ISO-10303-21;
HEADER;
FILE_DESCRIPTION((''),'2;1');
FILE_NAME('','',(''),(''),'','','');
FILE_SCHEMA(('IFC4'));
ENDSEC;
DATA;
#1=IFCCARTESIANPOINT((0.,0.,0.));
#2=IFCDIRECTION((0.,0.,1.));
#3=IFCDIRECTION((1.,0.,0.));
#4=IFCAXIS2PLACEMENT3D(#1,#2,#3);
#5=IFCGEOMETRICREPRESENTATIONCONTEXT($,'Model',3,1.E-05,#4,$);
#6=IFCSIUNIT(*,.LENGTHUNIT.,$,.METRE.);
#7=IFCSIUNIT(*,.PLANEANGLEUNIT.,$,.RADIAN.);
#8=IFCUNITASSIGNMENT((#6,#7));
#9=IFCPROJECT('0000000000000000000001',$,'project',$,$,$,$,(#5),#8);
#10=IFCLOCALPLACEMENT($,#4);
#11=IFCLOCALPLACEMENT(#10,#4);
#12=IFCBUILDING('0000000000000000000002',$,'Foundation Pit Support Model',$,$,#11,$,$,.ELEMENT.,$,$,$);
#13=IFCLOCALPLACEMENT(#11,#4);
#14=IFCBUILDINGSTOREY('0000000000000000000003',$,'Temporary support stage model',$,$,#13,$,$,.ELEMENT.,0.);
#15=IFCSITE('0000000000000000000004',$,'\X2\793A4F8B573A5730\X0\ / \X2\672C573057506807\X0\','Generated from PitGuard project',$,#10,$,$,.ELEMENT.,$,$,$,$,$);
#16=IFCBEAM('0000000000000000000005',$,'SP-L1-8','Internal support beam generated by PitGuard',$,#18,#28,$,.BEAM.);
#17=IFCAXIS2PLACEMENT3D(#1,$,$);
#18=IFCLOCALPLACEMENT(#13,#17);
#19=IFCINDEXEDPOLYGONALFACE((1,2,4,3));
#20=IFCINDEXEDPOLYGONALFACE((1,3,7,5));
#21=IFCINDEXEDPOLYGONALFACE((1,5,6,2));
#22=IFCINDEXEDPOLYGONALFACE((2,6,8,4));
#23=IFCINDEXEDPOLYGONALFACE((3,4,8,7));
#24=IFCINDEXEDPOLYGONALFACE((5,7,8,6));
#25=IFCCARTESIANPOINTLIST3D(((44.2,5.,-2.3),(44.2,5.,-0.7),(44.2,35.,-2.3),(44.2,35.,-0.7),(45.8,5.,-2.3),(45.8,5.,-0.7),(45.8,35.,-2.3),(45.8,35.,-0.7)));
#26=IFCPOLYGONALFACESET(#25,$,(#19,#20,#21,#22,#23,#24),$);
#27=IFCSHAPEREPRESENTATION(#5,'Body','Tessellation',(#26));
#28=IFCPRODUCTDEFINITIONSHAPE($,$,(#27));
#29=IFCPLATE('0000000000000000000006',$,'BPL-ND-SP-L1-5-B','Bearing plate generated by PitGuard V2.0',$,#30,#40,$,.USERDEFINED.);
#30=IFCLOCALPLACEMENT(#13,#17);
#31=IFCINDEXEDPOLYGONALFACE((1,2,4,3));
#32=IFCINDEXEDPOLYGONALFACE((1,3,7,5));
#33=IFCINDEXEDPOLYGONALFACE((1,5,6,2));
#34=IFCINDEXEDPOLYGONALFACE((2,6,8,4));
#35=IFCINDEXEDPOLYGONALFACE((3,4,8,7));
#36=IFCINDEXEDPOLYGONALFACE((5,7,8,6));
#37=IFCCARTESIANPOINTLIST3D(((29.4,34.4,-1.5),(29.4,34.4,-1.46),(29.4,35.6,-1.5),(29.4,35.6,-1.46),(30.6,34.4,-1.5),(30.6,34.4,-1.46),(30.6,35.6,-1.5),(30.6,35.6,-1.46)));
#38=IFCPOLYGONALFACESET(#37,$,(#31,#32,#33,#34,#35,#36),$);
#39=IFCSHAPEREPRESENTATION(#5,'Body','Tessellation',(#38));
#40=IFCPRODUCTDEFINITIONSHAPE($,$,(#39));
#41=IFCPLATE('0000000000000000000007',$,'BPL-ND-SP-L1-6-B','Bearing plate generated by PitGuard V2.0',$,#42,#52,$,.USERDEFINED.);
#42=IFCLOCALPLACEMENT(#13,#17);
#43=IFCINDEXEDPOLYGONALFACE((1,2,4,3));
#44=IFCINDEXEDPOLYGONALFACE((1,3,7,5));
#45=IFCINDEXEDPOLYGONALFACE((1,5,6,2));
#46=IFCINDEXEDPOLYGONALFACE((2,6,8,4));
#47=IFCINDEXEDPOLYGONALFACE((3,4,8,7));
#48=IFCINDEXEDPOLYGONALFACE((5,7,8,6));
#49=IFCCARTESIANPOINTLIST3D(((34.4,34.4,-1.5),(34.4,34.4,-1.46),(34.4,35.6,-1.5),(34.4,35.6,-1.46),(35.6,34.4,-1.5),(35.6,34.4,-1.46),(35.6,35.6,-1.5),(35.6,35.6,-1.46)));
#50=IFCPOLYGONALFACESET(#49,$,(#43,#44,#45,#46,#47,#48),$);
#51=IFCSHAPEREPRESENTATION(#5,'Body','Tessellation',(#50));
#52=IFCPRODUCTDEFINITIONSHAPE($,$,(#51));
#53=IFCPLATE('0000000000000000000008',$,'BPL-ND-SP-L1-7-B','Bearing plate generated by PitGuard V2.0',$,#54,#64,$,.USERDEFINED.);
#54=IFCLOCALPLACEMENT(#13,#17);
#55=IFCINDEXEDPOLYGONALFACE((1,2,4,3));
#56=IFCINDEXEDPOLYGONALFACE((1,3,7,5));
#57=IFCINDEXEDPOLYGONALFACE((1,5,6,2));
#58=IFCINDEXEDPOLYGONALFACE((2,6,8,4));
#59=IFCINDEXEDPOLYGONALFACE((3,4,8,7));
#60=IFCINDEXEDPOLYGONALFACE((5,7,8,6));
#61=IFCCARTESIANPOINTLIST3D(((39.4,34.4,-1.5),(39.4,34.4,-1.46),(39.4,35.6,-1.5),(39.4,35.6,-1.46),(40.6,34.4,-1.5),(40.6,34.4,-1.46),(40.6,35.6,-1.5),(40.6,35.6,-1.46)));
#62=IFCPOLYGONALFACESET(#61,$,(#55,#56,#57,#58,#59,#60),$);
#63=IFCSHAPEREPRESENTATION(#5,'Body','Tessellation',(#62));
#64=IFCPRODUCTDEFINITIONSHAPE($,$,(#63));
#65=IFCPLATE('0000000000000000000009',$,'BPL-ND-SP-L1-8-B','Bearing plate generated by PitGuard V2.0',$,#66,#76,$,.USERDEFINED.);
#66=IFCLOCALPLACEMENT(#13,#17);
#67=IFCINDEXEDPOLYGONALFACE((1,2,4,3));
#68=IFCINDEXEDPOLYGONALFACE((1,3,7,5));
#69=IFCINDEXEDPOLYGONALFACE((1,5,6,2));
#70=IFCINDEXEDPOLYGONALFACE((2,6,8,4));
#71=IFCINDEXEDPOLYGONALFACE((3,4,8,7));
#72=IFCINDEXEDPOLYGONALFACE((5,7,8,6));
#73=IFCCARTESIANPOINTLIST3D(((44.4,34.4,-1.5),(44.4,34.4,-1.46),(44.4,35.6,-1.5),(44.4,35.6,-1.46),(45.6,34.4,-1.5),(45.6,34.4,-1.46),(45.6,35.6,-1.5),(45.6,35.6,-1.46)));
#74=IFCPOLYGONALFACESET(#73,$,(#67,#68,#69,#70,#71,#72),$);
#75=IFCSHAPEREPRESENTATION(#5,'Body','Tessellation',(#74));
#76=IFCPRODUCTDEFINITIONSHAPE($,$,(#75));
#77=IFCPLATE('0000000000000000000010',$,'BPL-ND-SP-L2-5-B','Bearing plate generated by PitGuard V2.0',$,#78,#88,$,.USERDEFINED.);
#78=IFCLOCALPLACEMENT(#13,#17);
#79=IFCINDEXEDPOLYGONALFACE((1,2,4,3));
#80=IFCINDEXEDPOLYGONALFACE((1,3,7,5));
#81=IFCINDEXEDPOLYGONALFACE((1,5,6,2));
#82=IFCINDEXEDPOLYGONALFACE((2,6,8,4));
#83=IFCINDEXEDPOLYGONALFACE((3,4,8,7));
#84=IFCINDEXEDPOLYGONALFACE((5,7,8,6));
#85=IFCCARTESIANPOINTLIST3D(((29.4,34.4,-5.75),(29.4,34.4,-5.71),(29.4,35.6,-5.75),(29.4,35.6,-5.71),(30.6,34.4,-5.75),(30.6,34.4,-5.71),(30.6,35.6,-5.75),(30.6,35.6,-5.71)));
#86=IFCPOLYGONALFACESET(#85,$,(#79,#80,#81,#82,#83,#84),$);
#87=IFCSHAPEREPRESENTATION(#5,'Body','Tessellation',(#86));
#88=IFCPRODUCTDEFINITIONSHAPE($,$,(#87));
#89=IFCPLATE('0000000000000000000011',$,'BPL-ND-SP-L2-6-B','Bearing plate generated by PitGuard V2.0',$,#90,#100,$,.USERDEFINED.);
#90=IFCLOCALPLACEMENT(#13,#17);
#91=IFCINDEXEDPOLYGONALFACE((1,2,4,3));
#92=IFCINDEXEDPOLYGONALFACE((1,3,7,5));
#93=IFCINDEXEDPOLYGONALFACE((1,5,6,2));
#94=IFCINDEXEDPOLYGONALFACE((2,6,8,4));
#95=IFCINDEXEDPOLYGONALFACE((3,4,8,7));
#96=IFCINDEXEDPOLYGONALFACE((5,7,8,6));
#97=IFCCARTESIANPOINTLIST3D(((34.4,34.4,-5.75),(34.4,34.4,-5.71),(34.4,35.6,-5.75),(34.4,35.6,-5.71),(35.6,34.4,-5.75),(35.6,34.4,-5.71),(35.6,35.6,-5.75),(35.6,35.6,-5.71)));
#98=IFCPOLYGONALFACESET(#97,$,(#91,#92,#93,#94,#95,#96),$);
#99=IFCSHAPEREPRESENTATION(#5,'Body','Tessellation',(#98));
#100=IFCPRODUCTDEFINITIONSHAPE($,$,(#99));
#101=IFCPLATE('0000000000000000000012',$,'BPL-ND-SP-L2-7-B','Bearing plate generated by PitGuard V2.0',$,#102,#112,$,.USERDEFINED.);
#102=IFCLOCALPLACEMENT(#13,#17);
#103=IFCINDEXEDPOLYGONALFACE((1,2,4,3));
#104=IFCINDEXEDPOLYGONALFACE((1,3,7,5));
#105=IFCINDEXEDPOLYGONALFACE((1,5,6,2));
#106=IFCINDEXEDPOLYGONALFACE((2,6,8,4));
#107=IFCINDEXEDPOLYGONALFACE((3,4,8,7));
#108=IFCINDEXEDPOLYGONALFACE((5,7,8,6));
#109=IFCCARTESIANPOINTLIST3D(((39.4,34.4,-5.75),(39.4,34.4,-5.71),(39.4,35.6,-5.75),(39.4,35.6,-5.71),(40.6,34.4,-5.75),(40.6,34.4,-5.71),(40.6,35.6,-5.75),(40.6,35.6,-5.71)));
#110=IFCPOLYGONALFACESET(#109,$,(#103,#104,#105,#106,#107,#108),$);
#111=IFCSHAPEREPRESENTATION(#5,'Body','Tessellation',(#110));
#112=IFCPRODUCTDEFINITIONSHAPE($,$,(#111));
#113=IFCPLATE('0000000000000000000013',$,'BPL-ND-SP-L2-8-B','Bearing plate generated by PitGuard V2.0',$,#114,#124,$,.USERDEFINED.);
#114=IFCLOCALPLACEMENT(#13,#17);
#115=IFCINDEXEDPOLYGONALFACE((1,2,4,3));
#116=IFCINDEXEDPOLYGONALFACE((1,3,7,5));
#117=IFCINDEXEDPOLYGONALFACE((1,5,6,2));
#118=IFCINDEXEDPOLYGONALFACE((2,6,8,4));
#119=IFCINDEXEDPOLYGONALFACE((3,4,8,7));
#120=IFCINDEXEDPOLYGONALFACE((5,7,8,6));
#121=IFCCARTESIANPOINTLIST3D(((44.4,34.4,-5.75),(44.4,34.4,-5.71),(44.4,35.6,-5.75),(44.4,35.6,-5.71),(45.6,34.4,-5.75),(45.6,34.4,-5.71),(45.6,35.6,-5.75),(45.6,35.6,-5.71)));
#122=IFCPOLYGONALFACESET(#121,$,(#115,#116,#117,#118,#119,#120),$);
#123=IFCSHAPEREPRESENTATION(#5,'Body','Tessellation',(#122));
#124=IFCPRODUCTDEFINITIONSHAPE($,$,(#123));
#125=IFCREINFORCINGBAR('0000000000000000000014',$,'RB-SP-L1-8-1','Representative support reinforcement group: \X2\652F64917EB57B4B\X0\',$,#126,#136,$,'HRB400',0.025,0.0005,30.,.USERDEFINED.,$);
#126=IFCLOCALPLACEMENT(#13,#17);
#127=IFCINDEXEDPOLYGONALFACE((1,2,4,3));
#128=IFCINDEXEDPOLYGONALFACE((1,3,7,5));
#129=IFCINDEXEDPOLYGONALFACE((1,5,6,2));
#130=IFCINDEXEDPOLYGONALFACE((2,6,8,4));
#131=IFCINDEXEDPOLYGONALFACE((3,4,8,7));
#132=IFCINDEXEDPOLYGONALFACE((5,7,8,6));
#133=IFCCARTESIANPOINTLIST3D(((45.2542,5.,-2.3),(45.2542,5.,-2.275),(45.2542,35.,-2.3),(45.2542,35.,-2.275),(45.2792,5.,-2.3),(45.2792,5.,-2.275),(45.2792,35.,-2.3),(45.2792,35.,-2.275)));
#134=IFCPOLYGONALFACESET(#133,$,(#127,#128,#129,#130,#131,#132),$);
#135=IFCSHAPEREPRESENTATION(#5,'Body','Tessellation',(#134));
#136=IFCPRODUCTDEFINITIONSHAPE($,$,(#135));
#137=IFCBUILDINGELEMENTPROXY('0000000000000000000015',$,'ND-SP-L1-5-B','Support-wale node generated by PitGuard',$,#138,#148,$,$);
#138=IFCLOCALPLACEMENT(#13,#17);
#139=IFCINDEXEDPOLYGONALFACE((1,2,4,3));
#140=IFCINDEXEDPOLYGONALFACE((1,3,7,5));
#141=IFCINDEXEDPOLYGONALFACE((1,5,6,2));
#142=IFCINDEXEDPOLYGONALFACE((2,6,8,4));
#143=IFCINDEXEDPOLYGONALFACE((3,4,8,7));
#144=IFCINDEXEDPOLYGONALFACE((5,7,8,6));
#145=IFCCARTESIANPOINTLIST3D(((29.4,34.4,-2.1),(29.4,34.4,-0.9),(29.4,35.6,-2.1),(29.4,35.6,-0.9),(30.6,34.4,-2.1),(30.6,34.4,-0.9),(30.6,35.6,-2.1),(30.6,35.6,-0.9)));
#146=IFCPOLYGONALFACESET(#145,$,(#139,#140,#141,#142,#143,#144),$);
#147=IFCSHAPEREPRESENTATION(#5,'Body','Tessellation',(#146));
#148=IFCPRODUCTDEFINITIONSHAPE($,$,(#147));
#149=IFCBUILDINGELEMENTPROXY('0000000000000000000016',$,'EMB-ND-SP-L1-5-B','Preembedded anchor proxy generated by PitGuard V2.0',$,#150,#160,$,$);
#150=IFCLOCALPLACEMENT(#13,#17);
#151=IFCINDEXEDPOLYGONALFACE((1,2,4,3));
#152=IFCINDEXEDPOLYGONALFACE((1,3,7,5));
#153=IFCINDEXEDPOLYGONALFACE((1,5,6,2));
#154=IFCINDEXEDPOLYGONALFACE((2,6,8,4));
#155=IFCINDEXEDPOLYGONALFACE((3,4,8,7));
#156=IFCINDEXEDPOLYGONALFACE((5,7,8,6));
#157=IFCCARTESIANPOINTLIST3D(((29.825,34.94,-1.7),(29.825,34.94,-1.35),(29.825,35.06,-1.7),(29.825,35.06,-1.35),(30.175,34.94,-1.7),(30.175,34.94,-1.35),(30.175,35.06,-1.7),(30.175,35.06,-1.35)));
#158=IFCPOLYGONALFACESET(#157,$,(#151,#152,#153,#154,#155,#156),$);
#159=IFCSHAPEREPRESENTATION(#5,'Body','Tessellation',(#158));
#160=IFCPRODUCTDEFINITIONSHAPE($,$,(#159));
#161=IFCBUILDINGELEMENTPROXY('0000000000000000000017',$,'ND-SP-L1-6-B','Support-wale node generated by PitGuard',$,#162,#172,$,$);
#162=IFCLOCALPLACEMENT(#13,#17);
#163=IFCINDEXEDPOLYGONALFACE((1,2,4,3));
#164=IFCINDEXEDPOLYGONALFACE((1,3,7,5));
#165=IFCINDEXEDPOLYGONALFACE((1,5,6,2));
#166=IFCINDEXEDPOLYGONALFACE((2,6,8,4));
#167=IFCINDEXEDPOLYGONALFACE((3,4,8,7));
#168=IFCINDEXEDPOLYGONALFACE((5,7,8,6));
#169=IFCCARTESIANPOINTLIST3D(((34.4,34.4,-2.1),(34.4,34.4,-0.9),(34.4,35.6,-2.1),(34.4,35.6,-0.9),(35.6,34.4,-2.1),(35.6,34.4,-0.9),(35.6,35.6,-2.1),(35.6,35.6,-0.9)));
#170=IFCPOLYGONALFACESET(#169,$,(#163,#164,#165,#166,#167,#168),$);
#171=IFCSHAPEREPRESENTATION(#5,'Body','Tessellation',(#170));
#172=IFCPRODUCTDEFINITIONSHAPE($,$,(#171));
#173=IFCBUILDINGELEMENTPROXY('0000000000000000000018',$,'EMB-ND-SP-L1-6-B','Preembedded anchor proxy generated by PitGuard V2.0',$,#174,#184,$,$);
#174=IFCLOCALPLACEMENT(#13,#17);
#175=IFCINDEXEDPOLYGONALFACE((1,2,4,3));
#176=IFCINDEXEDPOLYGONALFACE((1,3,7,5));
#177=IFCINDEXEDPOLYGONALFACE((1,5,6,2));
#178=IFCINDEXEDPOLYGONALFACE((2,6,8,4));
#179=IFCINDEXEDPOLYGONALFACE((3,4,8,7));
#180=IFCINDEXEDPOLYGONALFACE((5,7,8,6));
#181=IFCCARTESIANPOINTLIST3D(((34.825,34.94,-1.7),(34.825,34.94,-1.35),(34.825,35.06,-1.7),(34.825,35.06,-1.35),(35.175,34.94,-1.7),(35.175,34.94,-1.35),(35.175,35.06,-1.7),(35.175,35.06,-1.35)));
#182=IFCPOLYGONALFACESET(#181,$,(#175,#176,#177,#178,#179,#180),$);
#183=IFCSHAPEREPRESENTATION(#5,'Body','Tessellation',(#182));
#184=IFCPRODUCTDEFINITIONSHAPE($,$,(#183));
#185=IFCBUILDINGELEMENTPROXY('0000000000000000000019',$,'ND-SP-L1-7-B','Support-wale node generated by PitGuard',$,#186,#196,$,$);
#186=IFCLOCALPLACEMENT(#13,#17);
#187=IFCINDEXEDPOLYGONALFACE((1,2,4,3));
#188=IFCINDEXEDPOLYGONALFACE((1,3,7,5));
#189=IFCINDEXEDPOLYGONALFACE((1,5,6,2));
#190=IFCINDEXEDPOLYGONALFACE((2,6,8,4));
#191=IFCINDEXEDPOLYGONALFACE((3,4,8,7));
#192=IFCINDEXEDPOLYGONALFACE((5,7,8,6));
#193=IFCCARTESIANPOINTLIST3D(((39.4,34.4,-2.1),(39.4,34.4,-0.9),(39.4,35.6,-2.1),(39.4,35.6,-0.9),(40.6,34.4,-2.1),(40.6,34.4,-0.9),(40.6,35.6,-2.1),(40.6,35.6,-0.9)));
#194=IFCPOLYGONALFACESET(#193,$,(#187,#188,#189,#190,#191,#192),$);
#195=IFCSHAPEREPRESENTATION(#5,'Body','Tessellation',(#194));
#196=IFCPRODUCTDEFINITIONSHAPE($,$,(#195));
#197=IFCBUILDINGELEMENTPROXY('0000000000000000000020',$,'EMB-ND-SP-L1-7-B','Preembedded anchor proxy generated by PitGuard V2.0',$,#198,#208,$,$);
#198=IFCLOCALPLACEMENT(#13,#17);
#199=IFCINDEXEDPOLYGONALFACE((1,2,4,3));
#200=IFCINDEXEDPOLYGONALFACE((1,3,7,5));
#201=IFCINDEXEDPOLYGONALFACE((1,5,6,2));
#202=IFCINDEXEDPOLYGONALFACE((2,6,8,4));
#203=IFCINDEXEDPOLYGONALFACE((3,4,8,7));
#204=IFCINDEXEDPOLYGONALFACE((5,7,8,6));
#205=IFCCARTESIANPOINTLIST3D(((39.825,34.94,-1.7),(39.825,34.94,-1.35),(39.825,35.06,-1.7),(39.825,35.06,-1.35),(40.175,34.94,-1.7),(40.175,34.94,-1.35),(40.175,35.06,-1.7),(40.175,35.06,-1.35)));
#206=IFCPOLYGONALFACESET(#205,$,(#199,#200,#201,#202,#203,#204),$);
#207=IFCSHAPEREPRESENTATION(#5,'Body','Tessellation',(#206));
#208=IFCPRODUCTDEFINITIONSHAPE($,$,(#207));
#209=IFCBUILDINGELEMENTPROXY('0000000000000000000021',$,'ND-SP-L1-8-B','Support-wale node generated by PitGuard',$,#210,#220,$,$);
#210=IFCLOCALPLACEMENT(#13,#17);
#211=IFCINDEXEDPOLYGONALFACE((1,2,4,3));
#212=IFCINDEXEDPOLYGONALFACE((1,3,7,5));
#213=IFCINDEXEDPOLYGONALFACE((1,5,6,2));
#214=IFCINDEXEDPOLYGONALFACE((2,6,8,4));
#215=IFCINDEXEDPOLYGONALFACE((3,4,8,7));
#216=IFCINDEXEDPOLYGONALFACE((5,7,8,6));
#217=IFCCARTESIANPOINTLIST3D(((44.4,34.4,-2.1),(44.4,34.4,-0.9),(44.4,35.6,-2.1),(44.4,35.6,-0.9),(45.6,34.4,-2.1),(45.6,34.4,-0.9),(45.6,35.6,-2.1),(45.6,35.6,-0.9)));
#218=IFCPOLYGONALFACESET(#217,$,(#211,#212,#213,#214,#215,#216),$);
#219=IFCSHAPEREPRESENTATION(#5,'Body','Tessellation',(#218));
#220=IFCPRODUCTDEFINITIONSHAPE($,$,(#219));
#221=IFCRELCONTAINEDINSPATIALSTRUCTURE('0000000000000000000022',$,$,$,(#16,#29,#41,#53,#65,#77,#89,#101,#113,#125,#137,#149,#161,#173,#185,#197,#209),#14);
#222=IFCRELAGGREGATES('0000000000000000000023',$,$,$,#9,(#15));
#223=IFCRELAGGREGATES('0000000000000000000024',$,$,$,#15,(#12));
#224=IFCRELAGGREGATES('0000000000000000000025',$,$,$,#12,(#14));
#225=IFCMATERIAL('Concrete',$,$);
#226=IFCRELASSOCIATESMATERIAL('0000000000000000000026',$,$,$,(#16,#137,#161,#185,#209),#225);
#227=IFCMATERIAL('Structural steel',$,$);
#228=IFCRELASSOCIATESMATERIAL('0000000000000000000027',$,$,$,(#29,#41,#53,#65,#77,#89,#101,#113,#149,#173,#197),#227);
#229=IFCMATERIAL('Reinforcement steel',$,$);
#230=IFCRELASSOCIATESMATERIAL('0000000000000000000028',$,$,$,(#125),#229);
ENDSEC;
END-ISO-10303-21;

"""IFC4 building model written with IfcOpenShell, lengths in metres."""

from ifc_helpers import new_model, si_unit, frame, origin_with_axes, origin_2d, place, context, project, spatial, rectangle, extrude, material, element, save


model = new_model("IFC4")

# Units and contexts
model_context = context("Model", 3, precision=1e-05, world=origin_with_axes())
ifc_project = project(units=[si_unit("LENGTHUNIT", "METRE"), si_unit("PLANEANGLEUNIT", "RADIAN")], contexts=[model_context])

# Site, building, storey
site_placement = place(None, origin_with_axes())
site = spatial("IfcSite", under=ifc_project, at=site_placement, Name="示例场地 / 本地坐标", Description="Generated from PitGuard project", CompositionType="ELEMENT")
building_placement = place(site_placement, origin_with_axes())
building = spatial("IfcBuilding", under=site, at=building_placement, Name="Foundation Pit Support Model", CompositionType="ELEMENT")
storey_placement = place(building_placement, origin_with_axes())
storey = spatial("IfcBuildingStorey", under=building, at=storey_placement, Name="Temporary support stage model", CompositionType="ELEMENT", Elevation=0.0)

# Beam
ifc_material_1 = material(Name="Concrete")
beam_placement = place(storey_placement, frame((45.0, 20.0, -2.3), z_axis=(0.0, 0.0, 1.0), x_axis=(0.0, 1.0, 0.0)))
element("IfcBeam", 1, at=beam_placement, inside=storey, material=ifc_material_1, Name="SP-L1-8", Description="Internal support beam generated by PitGuard", PredefinedType="BEAM", context=model_context, shape_type="SweptSolid", body=[
    extrude(rectangle(XDim=30.0, YDim=1.6, at=origin_2d()), origin_with_axes(), (0.0, 0.0, 1.0), 1.6),
])

# Plates
ifc_material_2 = material(Name="Structural steel")
for number, where, z_axis, x_axis, name in (
    (2, (30.0, 35.0, -1.5), (0.0, 0.0, 1.0), (1.0, 0.0, 0.0), "BPL-ND-SP-L1-5-B"),
    (3, (35.0, 35.0, -1.5), (0.0, 0.0, 1.0), (1.0, 0.0, 0.0), "BPL-ND-SP-L1-6-B"),
    (4, (40.0, 35.0, -1.5), (0.0, 0.0, 1.0), (1.0, 0.0, 0.0), "BPL-ND-SP-L1-7-B"),
    (5, (45.0, 35.0, -1.5), (0.0, 0.0, 1.0), (1.0, 0.0, 0.0), "BPL-ND-SP-L1-8-B"),
    (6, (30.0, 35.0, -5.75), (0.0, 0.0, 1.0), (1.0, 0.0, 0.0), "BPL-ND-SP-L2-5-B"),
    (7, (35.0, 35.0, -5.75), (0.0, 0.0, 1.0), (1.0, 0.0, 0.0), "BPL-ND-SP-L2-6-B"),
    (8, (40.0, 35.0, -5.75), (0.0, 0.0, 1.0), (1.0, 0.0, 0.0), "BPL-ND-SP-L2-7-B"),
    (9, (45.0, 35.0, -5.75), (0.0, 0.0, 1.0), (1.0, 0.0, 0.0), "BPL-ND-SP-L2-8-B"),
):
    element("IfcPlate", number, at=place(storey_placement, frame(where, z_axis=z_axis, x_axis=x_axis)), inside=storey, material=ifc_material_2, Name=name, Description="Bearing plate generated by PitGuard V2.0", PredefinedType="USERDEFINED", context=model_context, shape_type="SweptSolid", body=[
        extrude(rectangle(XDim=1.2, YDim=1.2, at=origin_2d()), origin_with_axes(), (0.0, 0.0, 1.0), 0.04),
    ])

# Reinforcing bar
ifc_material_3 = material(Name="Reinforcement steel")
reinforcing_bar_placement = place(storey_placement, frame((45.2667, 20.0, -2.3), z_axis=(0.0, 0.0, 1.0), x_axis=(0.0, 1.0, 0.0)))
element("IfcReinforcingBar", 10, at=reinforcing_bar_placement, inside=storey, material=ifc_material_3, Name="RB-SP-L1-8-1", Description="Representative support reinforcement group: 支撑纵筋", SteelGrade="HRB400", BarLength=30.0, CrossSectionArea=0.0005, NominalDiameter=0.025, PredefinedType="USERDEFINED", context=model_context, shape_type="SweptSolid", body=[
    extrude(rectangle(XDim=30.0, YDim=0.025, at=origin_2d()), origin_with_axes(), (0.0, 0.0, 1.0), 0.025),
])

# Building element proxies
proxy_1_placement = place(storey_placement, frame((30.0, 35.0, -2.1), z_axis=(0.0, 0.0, 1.0), x_axis=(1.0, 0.0, 0.0)))
element("IfcBuildingElementProxy", 11, at=proxy_1_placement, inside=storey, material=ifc_material_1, Name="ND-SP-L1-5-B", Description="Support-wale node generated by PitGuard", context=model_context, shape_type="SweptSolid", body=[
    extrude(rectangle(XDim=1.2, YDim=1.2, at=origin_2d()), origin_with_axes(), (0.0, 0.0, 1.0), 1.2),
])
proxy_2_placement = place(storey_placement, frame((30.0, 35.0, -1.7), z_axis=(0.0, 0.0, 1.0), x_axis=(1.0, 0.0, 0.0)))
element("IfcBuildingElementProxy", 12, at=proxy_2_placement, inside=storey, material=ifc_material_2, Name="EMB-ND-SP-L1-5-B", Description="Preembedded anchor proxy generated by PitGuard V2.0", context=model_context, shape_type="SweptSolid", body=[
    extrude(rectangle(XDim=0.35, YDim=0.12, at=origin_2d()), origin_with_axes(), (0.0, 0.0, 1.0), 0.35),
])
proxy_3_placement = place(storey_placement, frame((35.0, 35.0, -2.1), z_axis=(0.0, 0.0, 1.0), x_axis=(1.0, 0.0, 0.0)))
element("IfcBuildingElementProxy", 13, at=proxy_3_placement, inside=storey, material=ifc_material_1, Name="ND-SP-L1-6-B", Description="Support-wale node generated by PitGuard", context=model_context, shape_type="SweptSolid", body=[
    extrude(rectangle(XDim=1.2, YDim=1.2, at=origin_2d()), origin_with_axes(), (0.0, 0.0, 1.0), 1.2),
])
proxy_4_placement = place(storey_placement, frame((35.0, 35.0, -1.7), z_axis=(0.0, 0.0, 1.0), x_axis=(1.0, 0.0, 0.0)))
element("IfcBuildingElementProxy", 14, at=proxy_4_placement, inside=storey, material=ifc_material_2, Name="EMB-ND-SP-L1-6-B", Description="Preembedded anchor proxy generated by PitGuard V2.0", context=model_context, shape_type="SweptSolid", body=[
    extrude(rectangle(XDim=0.35, YDim=0.12, at=origin_2d()), origin_with_axes(), (0.0, 0.0, 1.0), 0.35),
])
proxy_5_placement = place(storey_placement, frame((40.0, 35.0, -2.1), z_axis=(0.0, 0.0, 1.0), x_axis=(1.0, 0.0, 0.0)))
element("IfcBuildingElementProxy", 15, at=proxy_5_placement, inside=storey, material=ifc_material_1, Name="ND-SP-L1-7-B", Description="Support-wale node generated by PitGuard", context=model_context, shape_type="SweptSolid", body=[
    extrude(rectangle(XDim=1.2, YDim=1.2, at=origin_2d()), origin_with_axes(), (0.0, 0.0, 1.0), 1.2),
])
proxy_6_placement = place(storey_placement, frame((40.0, 35.0, -1.7), z_axis=(0.0, 0.0, 1.0), x_axis=(1.0, 0.0, 0.0)))
element("IfcBuildingElementProxy", 16, at=proxy_6_placement, inside=storey, material=ifc_material_2, Name="EMB-ND-SP-L1-7-B", Description="Preembedded anchor proxy generated by PitGuard V2.0", context=model_context, shape_type="SweptSolid", body=[
    extrude(rectangle(XDim=0.35, YDim=0.12, at=origin_2d()), origin_with_axes(), (0.0, 0.0, 1.0), 0.35),
])
proxy_7_placement = place(storey_placement, frame((45.0, 35.0, -2.1), z_axis=(0.0, 0.0, 1.0), x_axis=(1.0, 0.0, 0.0)))
element("IfcBuildingElementProxy", 17, at=proxy_7_placement, inside=storey, material=ifc_material_1, Name="ND-SP-L1-8-B", Description="Support-wale node generated by PitGuard", context=model_context, shape_type="SweptSolid", body=[
    extrude(rectangle(XDim=1.2, YDim=1.2, at=origin_2d()), origin_with_axes(), (0.0, 0.0, 1.0), 1.2),
])

save(model, "model.ifc")
